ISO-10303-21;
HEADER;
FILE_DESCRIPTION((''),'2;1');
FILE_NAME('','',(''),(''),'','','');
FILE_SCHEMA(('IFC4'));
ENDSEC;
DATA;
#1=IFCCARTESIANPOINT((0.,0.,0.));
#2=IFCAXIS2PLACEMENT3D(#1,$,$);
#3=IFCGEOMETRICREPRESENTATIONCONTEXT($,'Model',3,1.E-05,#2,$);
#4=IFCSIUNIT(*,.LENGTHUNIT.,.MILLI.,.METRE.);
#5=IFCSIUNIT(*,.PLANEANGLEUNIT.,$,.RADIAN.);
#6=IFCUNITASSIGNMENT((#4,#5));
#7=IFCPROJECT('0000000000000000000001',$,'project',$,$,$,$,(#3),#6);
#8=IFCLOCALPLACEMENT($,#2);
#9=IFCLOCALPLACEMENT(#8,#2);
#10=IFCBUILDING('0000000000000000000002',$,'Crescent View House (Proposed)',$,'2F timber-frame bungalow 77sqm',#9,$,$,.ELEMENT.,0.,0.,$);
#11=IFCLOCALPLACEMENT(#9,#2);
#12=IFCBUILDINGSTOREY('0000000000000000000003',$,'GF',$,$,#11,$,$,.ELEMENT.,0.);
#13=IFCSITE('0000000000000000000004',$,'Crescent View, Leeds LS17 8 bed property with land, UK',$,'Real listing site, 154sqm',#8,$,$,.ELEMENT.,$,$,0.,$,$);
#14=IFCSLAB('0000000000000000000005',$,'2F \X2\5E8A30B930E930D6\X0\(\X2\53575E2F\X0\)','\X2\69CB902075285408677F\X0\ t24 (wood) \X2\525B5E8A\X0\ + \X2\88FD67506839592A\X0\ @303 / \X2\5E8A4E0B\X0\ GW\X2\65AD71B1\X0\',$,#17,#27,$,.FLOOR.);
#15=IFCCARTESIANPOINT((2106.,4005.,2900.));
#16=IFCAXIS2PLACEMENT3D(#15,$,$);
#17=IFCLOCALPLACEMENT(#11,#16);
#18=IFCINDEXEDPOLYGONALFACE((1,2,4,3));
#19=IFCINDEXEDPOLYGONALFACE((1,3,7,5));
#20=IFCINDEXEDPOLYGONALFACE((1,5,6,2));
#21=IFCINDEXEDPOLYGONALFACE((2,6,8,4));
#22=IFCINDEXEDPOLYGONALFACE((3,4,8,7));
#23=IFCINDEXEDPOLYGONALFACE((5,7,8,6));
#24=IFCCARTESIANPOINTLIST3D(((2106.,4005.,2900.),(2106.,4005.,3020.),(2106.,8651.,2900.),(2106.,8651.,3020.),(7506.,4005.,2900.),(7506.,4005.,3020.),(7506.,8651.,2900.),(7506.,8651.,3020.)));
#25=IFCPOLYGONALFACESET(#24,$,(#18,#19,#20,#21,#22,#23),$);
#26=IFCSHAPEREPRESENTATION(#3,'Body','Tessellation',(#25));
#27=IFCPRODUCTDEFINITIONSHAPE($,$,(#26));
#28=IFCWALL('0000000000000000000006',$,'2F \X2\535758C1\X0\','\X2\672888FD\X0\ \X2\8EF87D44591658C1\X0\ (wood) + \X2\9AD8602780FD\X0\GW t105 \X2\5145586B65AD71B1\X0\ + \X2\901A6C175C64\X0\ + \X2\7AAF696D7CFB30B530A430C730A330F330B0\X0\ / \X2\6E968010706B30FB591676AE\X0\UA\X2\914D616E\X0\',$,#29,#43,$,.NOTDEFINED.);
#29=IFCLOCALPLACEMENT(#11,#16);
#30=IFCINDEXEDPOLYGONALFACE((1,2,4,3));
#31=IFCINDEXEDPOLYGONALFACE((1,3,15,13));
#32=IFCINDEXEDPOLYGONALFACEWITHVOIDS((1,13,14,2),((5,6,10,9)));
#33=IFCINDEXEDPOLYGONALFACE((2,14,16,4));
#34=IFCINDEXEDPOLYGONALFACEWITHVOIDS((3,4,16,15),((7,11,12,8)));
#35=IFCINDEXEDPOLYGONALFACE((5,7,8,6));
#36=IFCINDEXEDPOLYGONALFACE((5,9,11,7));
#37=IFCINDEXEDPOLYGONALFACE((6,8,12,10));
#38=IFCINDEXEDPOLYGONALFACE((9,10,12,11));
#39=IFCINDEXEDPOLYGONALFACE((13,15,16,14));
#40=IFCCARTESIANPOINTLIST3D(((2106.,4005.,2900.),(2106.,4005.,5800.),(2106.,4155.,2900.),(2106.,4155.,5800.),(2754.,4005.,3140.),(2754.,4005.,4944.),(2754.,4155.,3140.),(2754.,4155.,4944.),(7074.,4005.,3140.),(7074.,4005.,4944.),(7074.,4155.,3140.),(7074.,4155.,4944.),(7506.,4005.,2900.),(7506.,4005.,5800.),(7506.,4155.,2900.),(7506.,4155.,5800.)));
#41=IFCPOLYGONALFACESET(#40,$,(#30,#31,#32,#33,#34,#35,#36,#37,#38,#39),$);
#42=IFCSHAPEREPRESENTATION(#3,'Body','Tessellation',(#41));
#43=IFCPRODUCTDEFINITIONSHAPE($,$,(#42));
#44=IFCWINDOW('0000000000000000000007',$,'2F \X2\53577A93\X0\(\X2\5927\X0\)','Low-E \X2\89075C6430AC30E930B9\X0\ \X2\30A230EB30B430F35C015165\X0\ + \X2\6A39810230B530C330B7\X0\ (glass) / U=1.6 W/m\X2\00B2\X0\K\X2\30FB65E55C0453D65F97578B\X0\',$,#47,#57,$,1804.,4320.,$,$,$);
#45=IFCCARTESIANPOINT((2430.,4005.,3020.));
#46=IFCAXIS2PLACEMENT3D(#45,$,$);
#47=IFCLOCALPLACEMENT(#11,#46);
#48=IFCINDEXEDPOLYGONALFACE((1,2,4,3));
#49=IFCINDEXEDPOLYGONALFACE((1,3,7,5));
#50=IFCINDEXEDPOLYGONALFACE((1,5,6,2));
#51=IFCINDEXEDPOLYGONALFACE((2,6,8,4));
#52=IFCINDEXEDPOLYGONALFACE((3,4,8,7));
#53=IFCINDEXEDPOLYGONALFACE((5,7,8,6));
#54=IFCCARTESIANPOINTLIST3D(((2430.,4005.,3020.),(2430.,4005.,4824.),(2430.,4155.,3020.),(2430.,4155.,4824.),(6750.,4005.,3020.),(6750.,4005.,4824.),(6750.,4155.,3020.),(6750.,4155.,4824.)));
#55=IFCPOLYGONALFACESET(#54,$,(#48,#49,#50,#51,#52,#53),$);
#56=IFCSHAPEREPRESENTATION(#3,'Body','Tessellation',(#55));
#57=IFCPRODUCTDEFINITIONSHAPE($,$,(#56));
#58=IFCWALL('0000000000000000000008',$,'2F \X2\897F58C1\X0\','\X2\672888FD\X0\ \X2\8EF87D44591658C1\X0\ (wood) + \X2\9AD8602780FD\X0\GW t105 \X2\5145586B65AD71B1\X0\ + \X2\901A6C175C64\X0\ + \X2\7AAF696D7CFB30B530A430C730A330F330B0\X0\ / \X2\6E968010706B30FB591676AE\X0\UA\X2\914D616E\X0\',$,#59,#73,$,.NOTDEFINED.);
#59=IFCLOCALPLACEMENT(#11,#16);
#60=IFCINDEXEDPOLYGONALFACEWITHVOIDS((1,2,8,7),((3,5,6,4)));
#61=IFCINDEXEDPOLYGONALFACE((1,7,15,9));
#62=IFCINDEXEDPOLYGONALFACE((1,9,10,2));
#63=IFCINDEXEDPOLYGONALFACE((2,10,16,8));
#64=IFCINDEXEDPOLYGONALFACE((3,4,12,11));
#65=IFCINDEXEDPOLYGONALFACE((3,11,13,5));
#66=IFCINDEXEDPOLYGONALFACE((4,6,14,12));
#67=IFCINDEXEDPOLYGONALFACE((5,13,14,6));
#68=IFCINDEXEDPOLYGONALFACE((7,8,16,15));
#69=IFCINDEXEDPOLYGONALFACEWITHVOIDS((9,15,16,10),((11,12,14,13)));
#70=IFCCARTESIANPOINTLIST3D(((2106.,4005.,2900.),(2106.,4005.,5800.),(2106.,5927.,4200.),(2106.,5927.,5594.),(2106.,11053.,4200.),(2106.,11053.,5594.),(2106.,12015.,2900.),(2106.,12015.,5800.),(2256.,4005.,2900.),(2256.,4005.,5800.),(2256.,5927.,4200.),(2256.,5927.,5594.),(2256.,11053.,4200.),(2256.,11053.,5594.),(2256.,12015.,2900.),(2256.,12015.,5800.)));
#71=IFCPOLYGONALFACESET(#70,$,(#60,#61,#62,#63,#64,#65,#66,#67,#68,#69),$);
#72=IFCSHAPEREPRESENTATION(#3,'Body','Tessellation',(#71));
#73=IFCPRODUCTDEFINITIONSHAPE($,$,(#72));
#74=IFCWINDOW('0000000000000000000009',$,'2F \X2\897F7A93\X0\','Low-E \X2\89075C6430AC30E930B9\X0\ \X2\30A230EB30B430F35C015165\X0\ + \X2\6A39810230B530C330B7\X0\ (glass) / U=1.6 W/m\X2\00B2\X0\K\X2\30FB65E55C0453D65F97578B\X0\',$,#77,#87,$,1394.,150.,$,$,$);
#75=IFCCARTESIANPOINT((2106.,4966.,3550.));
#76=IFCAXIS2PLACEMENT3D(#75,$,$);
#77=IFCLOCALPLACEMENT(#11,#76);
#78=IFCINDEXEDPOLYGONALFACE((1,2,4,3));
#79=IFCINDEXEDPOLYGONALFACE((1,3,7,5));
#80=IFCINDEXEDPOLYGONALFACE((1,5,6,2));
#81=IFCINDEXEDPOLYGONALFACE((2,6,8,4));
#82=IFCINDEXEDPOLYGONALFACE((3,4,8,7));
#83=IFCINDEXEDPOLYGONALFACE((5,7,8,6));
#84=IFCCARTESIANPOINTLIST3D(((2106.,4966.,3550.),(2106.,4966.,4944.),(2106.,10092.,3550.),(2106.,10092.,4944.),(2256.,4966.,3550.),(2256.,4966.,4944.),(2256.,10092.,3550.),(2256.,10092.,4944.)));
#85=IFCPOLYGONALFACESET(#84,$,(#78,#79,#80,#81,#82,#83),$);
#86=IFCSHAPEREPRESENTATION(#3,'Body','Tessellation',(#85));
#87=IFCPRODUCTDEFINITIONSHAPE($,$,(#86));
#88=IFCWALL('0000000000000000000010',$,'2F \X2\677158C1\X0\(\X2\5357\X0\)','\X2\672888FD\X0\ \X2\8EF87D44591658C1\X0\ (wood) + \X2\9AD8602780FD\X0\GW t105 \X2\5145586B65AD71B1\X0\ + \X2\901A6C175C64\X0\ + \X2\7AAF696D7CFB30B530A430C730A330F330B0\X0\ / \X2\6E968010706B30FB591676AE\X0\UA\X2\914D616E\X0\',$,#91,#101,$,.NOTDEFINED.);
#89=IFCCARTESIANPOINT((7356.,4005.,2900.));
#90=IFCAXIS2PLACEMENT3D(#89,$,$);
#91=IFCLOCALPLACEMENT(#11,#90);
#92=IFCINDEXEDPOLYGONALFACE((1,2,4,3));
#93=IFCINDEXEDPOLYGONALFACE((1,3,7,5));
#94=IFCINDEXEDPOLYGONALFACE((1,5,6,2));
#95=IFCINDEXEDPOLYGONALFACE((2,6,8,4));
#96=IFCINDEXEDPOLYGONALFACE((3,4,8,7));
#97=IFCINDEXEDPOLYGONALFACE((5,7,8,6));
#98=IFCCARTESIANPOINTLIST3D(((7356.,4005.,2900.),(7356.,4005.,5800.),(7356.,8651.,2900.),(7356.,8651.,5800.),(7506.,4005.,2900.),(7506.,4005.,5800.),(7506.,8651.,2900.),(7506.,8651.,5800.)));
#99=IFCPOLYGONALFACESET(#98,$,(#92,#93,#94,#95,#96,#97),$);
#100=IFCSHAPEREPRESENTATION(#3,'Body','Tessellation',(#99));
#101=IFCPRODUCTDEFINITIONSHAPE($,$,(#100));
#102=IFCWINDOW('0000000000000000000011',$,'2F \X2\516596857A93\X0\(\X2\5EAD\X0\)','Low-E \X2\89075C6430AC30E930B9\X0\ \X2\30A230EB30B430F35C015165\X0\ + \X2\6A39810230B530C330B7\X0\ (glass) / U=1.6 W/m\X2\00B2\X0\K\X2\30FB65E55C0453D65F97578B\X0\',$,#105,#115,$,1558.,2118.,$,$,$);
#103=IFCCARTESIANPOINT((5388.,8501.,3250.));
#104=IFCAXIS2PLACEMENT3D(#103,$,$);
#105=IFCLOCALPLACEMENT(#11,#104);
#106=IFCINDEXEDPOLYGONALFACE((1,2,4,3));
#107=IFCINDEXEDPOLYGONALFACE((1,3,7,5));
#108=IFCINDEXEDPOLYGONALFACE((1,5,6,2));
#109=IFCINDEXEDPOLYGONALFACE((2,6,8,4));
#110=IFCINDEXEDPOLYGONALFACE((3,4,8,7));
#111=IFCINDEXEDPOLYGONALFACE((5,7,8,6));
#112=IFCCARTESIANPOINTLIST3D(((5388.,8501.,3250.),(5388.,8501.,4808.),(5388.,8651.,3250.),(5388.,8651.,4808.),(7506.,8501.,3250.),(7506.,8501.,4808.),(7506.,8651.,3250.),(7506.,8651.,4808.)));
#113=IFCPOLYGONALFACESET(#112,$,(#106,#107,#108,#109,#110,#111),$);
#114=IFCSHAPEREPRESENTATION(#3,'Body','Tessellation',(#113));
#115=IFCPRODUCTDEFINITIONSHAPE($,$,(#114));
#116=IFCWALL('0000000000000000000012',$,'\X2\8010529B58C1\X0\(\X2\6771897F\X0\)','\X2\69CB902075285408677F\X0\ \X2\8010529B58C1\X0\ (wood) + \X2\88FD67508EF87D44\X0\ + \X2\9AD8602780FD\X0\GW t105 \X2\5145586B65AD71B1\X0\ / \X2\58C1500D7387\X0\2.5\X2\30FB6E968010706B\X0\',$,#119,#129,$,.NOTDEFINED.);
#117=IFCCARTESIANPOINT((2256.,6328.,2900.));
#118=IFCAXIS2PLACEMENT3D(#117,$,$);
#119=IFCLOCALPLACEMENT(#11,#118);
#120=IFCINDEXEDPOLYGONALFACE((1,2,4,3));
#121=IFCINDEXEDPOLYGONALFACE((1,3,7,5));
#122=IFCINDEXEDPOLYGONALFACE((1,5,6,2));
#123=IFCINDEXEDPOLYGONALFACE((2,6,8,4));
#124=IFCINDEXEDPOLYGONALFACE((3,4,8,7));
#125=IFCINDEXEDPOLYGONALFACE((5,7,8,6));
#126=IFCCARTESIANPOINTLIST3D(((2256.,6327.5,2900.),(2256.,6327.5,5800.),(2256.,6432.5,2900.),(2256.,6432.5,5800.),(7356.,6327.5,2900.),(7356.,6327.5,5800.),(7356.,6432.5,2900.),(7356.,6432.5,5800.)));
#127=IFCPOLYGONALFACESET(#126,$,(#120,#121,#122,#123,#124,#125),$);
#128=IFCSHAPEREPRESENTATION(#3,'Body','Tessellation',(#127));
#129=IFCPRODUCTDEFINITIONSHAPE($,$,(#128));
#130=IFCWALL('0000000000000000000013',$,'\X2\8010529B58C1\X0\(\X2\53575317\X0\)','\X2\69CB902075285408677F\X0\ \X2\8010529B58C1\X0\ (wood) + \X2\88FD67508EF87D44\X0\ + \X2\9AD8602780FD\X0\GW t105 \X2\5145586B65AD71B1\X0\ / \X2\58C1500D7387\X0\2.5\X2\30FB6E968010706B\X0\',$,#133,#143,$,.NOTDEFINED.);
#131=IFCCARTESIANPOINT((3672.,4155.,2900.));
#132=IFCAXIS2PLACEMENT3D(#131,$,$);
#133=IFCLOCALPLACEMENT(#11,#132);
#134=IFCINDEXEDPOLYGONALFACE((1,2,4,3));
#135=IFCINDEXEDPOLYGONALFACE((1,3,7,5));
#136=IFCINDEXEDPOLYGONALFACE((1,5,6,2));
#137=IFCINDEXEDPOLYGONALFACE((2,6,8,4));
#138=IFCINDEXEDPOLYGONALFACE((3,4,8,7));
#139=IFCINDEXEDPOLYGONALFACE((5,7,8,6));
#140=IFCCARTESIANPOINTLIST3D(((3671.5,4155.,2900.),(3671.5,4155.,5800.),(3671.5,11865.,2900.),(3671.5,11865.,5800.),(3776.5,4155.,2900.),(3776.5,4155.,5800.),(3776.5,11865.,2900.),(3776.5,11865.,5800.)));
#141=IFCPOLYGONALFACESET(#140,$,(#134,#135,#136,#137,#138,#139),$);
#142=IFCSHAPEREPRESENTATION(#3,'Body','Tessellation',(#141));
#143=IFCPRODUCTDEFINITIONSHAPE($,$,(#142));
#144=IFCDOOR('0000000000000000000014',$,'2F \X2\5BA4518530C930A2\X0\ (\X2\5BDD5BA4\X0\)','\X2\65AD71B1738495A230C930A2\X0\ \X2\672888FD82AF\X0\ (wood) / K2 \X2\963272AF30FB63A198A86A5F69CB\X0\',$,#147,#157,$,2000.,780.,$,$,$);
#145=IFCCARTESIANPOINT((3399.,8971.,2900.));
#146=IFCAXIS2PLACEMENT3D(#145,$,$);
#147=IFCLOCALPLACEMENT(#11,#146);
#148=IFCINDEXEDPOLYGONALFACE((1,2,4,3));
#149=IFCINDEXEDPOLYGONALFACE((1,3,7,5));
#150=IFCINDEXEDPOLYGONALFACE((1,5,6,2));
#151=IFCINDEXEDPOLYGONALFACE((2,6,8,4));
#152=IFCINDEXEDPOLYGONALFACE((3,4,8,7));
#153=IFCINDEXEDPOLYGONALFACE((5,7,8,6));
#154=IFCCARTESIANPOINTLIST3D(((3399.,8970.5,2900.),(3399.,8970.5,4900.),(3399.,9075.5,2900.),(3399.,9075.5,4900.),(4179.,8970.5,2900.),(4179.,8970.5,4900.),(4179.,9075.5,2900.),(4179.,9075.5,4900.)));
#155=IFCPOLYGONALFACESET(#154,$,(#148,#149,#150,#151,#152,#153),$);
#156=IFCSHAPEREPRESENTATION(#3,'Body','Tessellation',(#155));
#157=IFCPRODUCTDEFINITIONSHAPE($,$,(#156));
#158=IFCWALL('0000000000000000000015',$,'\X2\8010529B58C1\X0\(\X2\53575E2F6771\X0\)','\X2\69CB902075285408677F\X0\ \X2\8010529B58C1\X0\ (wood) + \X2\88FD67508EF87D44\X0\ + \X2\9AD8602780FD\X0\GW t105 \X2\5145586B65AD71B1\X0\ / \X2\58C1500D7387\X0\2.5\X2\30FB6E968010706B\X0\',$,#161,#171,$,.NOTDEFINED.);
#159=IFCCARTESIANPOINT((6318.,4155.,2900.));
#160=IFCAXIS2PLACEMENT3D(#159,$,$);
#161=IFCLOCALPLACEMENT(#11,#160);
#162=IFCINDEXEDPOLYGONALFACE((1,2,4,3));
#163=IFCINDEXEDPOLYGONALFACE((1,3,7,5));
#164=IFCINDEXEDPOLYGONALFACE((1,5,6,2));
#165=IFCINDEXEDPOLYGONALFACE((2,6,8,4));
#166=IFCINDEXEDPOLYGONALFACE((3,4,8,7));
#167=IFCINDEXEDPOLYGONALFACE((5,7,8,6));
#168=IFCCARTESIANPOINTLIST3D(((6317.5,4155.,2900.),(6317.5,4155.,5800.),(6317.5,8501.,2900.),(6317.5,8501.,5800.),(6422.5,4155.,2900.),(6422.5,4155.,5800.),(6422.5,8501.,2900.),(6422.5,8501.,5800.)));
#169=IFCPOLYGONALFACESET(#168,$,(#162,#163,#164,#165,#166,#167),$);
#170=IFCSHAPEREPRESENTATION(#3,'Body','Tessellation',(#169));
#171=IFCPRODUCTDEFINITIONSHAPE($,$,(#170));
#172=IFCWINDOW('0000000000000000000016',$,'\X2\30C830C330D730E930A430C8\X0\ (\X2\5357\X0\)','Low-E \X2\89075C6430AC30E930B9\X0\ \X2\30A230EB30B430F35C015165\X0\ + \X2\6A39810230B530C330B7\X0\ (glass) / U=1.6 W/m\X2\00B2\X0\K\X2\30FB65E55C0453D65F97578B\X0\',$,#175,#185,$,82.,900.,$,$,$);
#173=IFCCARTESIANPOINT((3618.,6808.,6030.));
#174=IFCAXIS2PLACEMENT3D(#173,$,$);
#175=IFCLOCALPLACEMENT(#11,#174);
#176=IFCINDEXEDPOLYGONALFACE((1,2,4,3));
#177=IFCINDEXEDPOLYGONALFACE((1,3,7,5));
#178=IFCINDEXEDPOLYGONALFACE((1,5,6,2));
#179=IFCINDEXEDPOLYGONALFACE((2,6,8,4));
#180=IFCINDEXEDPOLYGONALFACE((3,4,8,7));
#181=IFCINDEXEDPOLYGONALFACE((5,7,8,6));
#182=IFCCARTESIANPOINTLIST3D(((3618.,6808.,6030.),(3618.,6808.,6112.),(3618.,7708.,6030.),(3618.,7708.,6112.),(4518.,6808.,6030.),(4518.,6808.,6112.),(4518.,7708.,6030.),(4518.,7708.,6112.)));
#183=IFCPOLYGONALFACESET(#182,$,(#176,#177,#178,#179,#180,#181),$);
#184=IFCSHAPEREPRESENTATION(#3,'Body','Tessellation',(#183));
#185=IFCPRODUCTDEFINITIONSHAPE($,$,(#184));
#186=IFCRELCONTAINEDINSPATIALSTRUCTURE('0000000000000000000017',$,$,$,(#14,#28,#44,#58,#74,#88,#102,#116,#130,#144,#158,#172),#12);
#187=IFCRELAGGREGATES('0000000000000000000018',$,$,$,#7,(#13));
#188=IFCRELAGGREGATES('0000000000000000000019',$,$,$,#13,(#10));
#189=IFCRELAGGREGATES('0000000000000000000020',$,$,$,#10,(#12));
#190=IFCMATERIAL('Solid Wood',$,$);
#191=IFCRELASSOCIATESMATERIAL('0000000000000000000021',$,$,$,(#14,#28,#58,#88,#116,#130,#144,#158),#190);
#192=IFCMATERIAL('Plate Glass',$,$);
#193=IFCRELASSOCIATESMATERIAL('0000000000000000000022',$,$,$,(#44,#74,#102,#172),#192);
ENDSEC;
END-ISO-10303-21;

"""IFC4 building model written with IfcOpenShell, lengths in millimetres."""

from ifc_helpers import new_model, si_unit, frame, frame_2d, origin, place, context, project, spatial, rectangle, extrude, material, element, fill, save


model = new_model("IFC4")

# Units and contexts
model_context = context("Model", 3, precision=1e-05, world=origin())
ifc_project = project(units=[si_unit("LENGTHUNIT", "METRE", prefix="MILLI"), si_unit("PLANEANGLEUNIT", "RADIAN")], contexts=[model_context])

# Site, building, storey
site_placement = place(None, origin())
site = spatial("IfcSite", under=ifc_project, at=site_placement, Name="Crescent View, Leeds LS17 8 bed property with land, UK", ObjectType="Real listing site, 154sqm", CompositionType="ELEMENT", RefElevation=0.0)
building_placement = place(site_placement, origin())
building = spatial("IfcBuilding", under=site, at=building_placement, Name="Crescent View House (Proposed)", ObjectType="2F timber-frame bungalow 77sqm", CompositionType="ELEMENT", ElevationOfRefHeight=0.0, ElevationOfTerrain=0.0)
storey_placement = place(building_placement, origin())
storey = spatial("IfcBuildingStorey", under=building, at=storey_placement, Name="GF", CompositionType="ELEMENT", Elevation=0.0)

# Slab
ifc_material_1 = material(Name="Solid Wood")
slab_placement = place(storey_placement, frame((2106.0, 4005.0, 2900.0)))
element("IfcSlab", 1, at=slab_placement, inside=storey, material=ifc_material_1, Name="2F 床スラブ(南帯)", Description="構造用合板 t24 (wood) 剛床 + 製材根太 @303 / 床下 GW断熱", PredefinedType="FLOOR", context=model_context, shape_type="SweptSolid", body=[
    extrude(rectangle(XDim=5400.0, YDim=4646.0, at=frame_2d((2700.0, 2323.0))), frame((2106.0, 4005.0, 2900.0)), (0.0, 0.0, 1.0), 120.0),
])

# Walls, openings, windows
wall_1_placement = place(storey_placement, frame((2106.0, 4005.0, 2900.0)))
wall_1 = element("IfcWall", 2, at=wall_1_placement, inside=storey, material=ifc_material_1, Name="2F 南壁", Description="木製 軸組外壁 (wood) + 高性能GW t105 充填断熱 + 通気層 + 窯業系サイディング / 準耐火・外皮UA配慮", PredefinedType="NOTDEFINED", context=model_context, shape_type="SweptSolid", body=[
    extrude(rectangle(XDim=5400.0, YDim=150.0, at=frame_2d((2700.0, 75.0))), frame((2106.0, 4005.0, 2900.0)), (0.0, 0.0, 1.0), 2900.0),
])
opening_1_placement = place(storey_placement, frame((2430.0, 4005.0, 3020.0)))
opening_1 = element("IfcOpeningElement", 3, at=opening_1_placement, cuts=wall_1, PredefinedType="NOTDEFINED", context=model_context, shape_type="SweptSolid", body=[
    extrude(rectangle(XDim=4320.0, YDim=150.0, at=frame_2d((2160.0, 75.0))), frame((2430.0, 4005.0, 3020.0)), (0.0, 0.0, 1.0), 1804.0),
])
ifc_material_2 = material(Name="Plate Glass")
window_1_placement = place(storey_placement, frame((2430.0, 4005.0, 3020.0)))
window_1 = element("IfcWindow", 4, at=window_1_placement, inside=storey, material=ifc_material_2, Name="2F 南窓(大)", Description="Low-E 複層ガラス アルゴン封入 + 樹脂サッシ (glass) / U=1.6 W/m²K・日射取得型", OverallHeight=1804.0, OverallWidth=4320.0, context=model_context, shape_type="SweptSolid", body=[
    extrude(rectangle(XDim=4320.0, YDim=150.0, at=frame_2d((2160.0, 75.0))), frame((2430.0, 4005.0, 3020.0)), (0.0, 0.0, 1.0), 1804.0),
])
fill(opening_1, window_1)
wall_2_placement = place(storey_placement, frame((2106.0, 4005.0, 2900.0)))
wall_2 = element("IfcWall", 5, at=wall_2_placement, inside=storey, material=ifc_material_1, Name="2F 西壁", Description="木製 軸組外壁 (wood) + 高性能GW t105 充填断熱 + 通気層 + 窯業系サイディング / 準耐火・外皮UA配慮", PredefinedType="NOTDEFINED", context=model_context, shape_type="SweptSolid", body=[
    extrude(rectangle(XDim=150.0, YDim=8010.0, at=frame_2d((75.0, 4005.0))), frame((2106.0, 4005.0, 2900.0)), (0.0, 0.0, 1.0), 2900.0),
])
opening_2_placement = place(storey_placement, frame((2106.0, 4966.0, 3550.0)))
opening_2 = element("IfcOpeningElement", 6, at=opening_2_placement, cuts=wall_2, PredefinedType="NOTDEFINED", context=model_context, shape_type="SweptSolid", body=[
    extrude(rectangle(XDim=150.0, YDim=5126.0, at=frame_2d((75.0, 2563.0))), frame((2106.0, 4966.0, 3550.0)), (0.0, 0.0, 1.0), 1394.0),
])
window_2_placement = place(storey_placement, frame((2106.0, 4966.0, 3550.0)))
window_2 = element("IfcWindow", 7, at=window_2_placement, inside=storey, material=ifc_material_2, Name="2F 西窓", Description="Low-E 複層ガラス アルゴン封入 + 樹脂サッシ (glass) / U=1.6 W/m²K・日射取得型", OverallHeight=1394.0, OverallWidth=150.0, context=model_context, shape_type="SweptSolid", body=[
    extrude(rectangle(XDim=150.0, YDim=5126.0, at=frame_2d((75.0, 2563.0))), frame((2106.0, 4966.0, 3550.0)), (0.0, 0.0, 1.0), 1394.0),
])
fill(opening_2, window_2)
wall_3_placement = place(storey_placement, frame((7356.0, 4005.0, 2900.0)))
wall_3 = element("IfcWall", 8, at=wall_3_placement, inside=storey, material=ifc_material_1, Name="2F 東壁(南)", Description="木製 軸組外壁 (wood) + 高性能GW t105 充填断熱 + 通気層 + 窯業系サイディング / 準耐火・外皮UA配慮", PredefinedType="NOTDEFINED", context=model_context, shape_type="SweptSolid", body=[
    extrude(rectangle(XDim=150.0, YDim=4646.0, at=frame_2d((75.0, 2323.0))), frame((7356.0, 4005.0, 2900.0)), (0.0, 0.0, 1.0), 2900.0),
])
opening_3_placement = place(storey_placement, frame((5388.0, 8501.0, 3250.0)))
opening_3 = element("IfcOpeningElement", 9, at=opening_3_placement, cuts=wall_3, PredefinedType="NOTDEFINED", context=model_context, shape_type="SweptSolid", body=[
    extrude(rectangle(XDim=2118.0, YDim=150.0, at=frame_2d((1059.0, 75.0))), frame((5388.0, 8501.0, 3250.0)), (0.0, 0.0, 1.0), 1558.0),
])
window_3_placement = place(storey_placement, frame((5388.0, 8501.0, 3250.0)))
window_3 = element("IfcWindow", 10, at=window_3_placement, inside=storey, material=ifc_material_2, Name="2F 入隅窓(庭)", Description="Low-E 複層ガラス アルゴン封入 + 樹脂サッシ (glass) / U=1.6 W/m²K・日射取得型", OverallHeight=1558.0, OverallWidth=2118.0, context=model_context, shape_type="SweptSolid", body=[
    extrude(rectangle(XDim=2118.0, YDim=150.0, at=frame_2d((1059.0, 75.0))), frame((5388.0, 8501.0, 3250.0)), (0.0, 0.0, 1.0), 1558.0),
])
fill(opening_3, window_3)

# Wall
wall_4_placement = place(storey_placement, frame((2256.0, 6328.0, 2900.0)))
element("IfcWall", 11, at=wall_4_placement, inside=storey, material=ifc_material_1, Name="耐力壁(東西)", Description="構造用合板 耐力壁 (wood) + 製材軸組 + 高性能GW t105 充填断熱 / 壁倍率2.5・準耐火", PredefinedType="NOTDEFINED", context=model_context, shape_type="SweptSolid", body=[
    extrude(rectangle(XDim=5100.0, YDim=105.0, at=frame_2d((2550.0, 52.0))), frame((2256.0, 6328.0, 2900.0)), (0.0, 0.0, 1.0), 2900.0),
])

# Wall, opening, door
wall_5_placement = place(storey_placement, frame((3672.0, 4155.0, 2900.0)))
wall_5 = element("IfcWall", 12, at=wall_5_placement, inside=storey, material=ifc_material_1, Name="耐力壁(南北)", Description="構造用合板 耐力壁 (wood) + 製材軸組 + 高性能GW t105 充填断熱 / 壁倍率2.5・準耐火", PredefinedType="NOTDEFINED", context=model_context, shape_type="SweptSolid", body=[
    extrude(rectangle(XDim=105.0, YDim=7710.0, at=frame_2d((52.0, 3855.0))), frame((3672.0, 4155.0, 2900.0)), (0.0, 0.0, 1.0), 2900.0),
])
opening_4_placement = place(storey_placement, frame((3399.0, 8971.0, 2900.0)))
opening_4 = element("IfcOpeningElement", 13, at=opening_4_placement, cuts=wall_5, PredefinedType="NOTDEFINED", context=model_context, shape_type="SweptSolid", body=[
    extrude(rectangle(XDim=780.0, YDim=105.0, at=frame_2d((390.0, 52.0))), frame((3399.0, 8971.0, 2900.0)), (0.0, 0.0, 1.0), 2000.0),
])
door_placement = place(storey_placement, frame((3399.0, 8971.0, 2900.0)))
door = element("IfcDoor", 14, at=door_placement, inside=storey, material=ifc_material_1, Name="2F 室内ドア (寝室)", Description="断熱玄関ドア 木製芯 (wood) / K2 防犯・採風機構", OverallHeight=2000.0, OverallWidth=780.0, context=model_context, shape_type="SweptSolid", body=[
    extrude(rectangle(XDim=780.0, YDim=105.0, at=frame_2d((390.0, 52.0))), frame((3399.0, 8971.0, 2900.0)), (0.0, 0.0, 1.0), 2000.0),
])
fill(opening_4, door)

# Wall
wall_6_placement = place(storey_placement, frame((6318.0, 4155.0, 2900.0)))
element("IfcWall", 15, at=wall_6_placement, inside=storey, material=ifc_material_1, Name="耐力壁(南帯東)", Description="構造用合板 耐力壁 (wood) + 製材軸組 + 高性能GW t105 充填断熱 / 壁倍率2.5・準耐火", PredefinedType="NOTDEFINED", context=model_context, shape_type="SweptSolid", body=[
    extrude(rectangle(XDim=105.0, YDim=4346.0, at=frame_2d((52.0, 2173.0))), frame((6318.0, 4155.0, 2900.0)), (0.0, 0.0, 1.0), 2900.0),
])

# Window
window_4_placement = place(storey_placement, frame((3618.0, 6808.0, 6030.0)))
element("IfcWindow", 16, at=window_4_placement, inside=storey, material=ifc_material_2, Name="トップライト (南)", Description="Low-E 複層ガラス アルゴン封入 + 樹脂サッシ (glass) / U=1.6 W/m²K・日射取得型", OverallHeight=82.0, OverallWidth=900.0, context=model_context, shape_type="SweptSolid", body=[
    extrude(rectangle(XDim=900.0, YDim=900.0, at=frame_2d((450.0, 450.0))), frame((3618.0, 6808.0, 6030.0)), (0.0, 0.0, 1.0), 82.0),
])

save(model, "model.ifc")
